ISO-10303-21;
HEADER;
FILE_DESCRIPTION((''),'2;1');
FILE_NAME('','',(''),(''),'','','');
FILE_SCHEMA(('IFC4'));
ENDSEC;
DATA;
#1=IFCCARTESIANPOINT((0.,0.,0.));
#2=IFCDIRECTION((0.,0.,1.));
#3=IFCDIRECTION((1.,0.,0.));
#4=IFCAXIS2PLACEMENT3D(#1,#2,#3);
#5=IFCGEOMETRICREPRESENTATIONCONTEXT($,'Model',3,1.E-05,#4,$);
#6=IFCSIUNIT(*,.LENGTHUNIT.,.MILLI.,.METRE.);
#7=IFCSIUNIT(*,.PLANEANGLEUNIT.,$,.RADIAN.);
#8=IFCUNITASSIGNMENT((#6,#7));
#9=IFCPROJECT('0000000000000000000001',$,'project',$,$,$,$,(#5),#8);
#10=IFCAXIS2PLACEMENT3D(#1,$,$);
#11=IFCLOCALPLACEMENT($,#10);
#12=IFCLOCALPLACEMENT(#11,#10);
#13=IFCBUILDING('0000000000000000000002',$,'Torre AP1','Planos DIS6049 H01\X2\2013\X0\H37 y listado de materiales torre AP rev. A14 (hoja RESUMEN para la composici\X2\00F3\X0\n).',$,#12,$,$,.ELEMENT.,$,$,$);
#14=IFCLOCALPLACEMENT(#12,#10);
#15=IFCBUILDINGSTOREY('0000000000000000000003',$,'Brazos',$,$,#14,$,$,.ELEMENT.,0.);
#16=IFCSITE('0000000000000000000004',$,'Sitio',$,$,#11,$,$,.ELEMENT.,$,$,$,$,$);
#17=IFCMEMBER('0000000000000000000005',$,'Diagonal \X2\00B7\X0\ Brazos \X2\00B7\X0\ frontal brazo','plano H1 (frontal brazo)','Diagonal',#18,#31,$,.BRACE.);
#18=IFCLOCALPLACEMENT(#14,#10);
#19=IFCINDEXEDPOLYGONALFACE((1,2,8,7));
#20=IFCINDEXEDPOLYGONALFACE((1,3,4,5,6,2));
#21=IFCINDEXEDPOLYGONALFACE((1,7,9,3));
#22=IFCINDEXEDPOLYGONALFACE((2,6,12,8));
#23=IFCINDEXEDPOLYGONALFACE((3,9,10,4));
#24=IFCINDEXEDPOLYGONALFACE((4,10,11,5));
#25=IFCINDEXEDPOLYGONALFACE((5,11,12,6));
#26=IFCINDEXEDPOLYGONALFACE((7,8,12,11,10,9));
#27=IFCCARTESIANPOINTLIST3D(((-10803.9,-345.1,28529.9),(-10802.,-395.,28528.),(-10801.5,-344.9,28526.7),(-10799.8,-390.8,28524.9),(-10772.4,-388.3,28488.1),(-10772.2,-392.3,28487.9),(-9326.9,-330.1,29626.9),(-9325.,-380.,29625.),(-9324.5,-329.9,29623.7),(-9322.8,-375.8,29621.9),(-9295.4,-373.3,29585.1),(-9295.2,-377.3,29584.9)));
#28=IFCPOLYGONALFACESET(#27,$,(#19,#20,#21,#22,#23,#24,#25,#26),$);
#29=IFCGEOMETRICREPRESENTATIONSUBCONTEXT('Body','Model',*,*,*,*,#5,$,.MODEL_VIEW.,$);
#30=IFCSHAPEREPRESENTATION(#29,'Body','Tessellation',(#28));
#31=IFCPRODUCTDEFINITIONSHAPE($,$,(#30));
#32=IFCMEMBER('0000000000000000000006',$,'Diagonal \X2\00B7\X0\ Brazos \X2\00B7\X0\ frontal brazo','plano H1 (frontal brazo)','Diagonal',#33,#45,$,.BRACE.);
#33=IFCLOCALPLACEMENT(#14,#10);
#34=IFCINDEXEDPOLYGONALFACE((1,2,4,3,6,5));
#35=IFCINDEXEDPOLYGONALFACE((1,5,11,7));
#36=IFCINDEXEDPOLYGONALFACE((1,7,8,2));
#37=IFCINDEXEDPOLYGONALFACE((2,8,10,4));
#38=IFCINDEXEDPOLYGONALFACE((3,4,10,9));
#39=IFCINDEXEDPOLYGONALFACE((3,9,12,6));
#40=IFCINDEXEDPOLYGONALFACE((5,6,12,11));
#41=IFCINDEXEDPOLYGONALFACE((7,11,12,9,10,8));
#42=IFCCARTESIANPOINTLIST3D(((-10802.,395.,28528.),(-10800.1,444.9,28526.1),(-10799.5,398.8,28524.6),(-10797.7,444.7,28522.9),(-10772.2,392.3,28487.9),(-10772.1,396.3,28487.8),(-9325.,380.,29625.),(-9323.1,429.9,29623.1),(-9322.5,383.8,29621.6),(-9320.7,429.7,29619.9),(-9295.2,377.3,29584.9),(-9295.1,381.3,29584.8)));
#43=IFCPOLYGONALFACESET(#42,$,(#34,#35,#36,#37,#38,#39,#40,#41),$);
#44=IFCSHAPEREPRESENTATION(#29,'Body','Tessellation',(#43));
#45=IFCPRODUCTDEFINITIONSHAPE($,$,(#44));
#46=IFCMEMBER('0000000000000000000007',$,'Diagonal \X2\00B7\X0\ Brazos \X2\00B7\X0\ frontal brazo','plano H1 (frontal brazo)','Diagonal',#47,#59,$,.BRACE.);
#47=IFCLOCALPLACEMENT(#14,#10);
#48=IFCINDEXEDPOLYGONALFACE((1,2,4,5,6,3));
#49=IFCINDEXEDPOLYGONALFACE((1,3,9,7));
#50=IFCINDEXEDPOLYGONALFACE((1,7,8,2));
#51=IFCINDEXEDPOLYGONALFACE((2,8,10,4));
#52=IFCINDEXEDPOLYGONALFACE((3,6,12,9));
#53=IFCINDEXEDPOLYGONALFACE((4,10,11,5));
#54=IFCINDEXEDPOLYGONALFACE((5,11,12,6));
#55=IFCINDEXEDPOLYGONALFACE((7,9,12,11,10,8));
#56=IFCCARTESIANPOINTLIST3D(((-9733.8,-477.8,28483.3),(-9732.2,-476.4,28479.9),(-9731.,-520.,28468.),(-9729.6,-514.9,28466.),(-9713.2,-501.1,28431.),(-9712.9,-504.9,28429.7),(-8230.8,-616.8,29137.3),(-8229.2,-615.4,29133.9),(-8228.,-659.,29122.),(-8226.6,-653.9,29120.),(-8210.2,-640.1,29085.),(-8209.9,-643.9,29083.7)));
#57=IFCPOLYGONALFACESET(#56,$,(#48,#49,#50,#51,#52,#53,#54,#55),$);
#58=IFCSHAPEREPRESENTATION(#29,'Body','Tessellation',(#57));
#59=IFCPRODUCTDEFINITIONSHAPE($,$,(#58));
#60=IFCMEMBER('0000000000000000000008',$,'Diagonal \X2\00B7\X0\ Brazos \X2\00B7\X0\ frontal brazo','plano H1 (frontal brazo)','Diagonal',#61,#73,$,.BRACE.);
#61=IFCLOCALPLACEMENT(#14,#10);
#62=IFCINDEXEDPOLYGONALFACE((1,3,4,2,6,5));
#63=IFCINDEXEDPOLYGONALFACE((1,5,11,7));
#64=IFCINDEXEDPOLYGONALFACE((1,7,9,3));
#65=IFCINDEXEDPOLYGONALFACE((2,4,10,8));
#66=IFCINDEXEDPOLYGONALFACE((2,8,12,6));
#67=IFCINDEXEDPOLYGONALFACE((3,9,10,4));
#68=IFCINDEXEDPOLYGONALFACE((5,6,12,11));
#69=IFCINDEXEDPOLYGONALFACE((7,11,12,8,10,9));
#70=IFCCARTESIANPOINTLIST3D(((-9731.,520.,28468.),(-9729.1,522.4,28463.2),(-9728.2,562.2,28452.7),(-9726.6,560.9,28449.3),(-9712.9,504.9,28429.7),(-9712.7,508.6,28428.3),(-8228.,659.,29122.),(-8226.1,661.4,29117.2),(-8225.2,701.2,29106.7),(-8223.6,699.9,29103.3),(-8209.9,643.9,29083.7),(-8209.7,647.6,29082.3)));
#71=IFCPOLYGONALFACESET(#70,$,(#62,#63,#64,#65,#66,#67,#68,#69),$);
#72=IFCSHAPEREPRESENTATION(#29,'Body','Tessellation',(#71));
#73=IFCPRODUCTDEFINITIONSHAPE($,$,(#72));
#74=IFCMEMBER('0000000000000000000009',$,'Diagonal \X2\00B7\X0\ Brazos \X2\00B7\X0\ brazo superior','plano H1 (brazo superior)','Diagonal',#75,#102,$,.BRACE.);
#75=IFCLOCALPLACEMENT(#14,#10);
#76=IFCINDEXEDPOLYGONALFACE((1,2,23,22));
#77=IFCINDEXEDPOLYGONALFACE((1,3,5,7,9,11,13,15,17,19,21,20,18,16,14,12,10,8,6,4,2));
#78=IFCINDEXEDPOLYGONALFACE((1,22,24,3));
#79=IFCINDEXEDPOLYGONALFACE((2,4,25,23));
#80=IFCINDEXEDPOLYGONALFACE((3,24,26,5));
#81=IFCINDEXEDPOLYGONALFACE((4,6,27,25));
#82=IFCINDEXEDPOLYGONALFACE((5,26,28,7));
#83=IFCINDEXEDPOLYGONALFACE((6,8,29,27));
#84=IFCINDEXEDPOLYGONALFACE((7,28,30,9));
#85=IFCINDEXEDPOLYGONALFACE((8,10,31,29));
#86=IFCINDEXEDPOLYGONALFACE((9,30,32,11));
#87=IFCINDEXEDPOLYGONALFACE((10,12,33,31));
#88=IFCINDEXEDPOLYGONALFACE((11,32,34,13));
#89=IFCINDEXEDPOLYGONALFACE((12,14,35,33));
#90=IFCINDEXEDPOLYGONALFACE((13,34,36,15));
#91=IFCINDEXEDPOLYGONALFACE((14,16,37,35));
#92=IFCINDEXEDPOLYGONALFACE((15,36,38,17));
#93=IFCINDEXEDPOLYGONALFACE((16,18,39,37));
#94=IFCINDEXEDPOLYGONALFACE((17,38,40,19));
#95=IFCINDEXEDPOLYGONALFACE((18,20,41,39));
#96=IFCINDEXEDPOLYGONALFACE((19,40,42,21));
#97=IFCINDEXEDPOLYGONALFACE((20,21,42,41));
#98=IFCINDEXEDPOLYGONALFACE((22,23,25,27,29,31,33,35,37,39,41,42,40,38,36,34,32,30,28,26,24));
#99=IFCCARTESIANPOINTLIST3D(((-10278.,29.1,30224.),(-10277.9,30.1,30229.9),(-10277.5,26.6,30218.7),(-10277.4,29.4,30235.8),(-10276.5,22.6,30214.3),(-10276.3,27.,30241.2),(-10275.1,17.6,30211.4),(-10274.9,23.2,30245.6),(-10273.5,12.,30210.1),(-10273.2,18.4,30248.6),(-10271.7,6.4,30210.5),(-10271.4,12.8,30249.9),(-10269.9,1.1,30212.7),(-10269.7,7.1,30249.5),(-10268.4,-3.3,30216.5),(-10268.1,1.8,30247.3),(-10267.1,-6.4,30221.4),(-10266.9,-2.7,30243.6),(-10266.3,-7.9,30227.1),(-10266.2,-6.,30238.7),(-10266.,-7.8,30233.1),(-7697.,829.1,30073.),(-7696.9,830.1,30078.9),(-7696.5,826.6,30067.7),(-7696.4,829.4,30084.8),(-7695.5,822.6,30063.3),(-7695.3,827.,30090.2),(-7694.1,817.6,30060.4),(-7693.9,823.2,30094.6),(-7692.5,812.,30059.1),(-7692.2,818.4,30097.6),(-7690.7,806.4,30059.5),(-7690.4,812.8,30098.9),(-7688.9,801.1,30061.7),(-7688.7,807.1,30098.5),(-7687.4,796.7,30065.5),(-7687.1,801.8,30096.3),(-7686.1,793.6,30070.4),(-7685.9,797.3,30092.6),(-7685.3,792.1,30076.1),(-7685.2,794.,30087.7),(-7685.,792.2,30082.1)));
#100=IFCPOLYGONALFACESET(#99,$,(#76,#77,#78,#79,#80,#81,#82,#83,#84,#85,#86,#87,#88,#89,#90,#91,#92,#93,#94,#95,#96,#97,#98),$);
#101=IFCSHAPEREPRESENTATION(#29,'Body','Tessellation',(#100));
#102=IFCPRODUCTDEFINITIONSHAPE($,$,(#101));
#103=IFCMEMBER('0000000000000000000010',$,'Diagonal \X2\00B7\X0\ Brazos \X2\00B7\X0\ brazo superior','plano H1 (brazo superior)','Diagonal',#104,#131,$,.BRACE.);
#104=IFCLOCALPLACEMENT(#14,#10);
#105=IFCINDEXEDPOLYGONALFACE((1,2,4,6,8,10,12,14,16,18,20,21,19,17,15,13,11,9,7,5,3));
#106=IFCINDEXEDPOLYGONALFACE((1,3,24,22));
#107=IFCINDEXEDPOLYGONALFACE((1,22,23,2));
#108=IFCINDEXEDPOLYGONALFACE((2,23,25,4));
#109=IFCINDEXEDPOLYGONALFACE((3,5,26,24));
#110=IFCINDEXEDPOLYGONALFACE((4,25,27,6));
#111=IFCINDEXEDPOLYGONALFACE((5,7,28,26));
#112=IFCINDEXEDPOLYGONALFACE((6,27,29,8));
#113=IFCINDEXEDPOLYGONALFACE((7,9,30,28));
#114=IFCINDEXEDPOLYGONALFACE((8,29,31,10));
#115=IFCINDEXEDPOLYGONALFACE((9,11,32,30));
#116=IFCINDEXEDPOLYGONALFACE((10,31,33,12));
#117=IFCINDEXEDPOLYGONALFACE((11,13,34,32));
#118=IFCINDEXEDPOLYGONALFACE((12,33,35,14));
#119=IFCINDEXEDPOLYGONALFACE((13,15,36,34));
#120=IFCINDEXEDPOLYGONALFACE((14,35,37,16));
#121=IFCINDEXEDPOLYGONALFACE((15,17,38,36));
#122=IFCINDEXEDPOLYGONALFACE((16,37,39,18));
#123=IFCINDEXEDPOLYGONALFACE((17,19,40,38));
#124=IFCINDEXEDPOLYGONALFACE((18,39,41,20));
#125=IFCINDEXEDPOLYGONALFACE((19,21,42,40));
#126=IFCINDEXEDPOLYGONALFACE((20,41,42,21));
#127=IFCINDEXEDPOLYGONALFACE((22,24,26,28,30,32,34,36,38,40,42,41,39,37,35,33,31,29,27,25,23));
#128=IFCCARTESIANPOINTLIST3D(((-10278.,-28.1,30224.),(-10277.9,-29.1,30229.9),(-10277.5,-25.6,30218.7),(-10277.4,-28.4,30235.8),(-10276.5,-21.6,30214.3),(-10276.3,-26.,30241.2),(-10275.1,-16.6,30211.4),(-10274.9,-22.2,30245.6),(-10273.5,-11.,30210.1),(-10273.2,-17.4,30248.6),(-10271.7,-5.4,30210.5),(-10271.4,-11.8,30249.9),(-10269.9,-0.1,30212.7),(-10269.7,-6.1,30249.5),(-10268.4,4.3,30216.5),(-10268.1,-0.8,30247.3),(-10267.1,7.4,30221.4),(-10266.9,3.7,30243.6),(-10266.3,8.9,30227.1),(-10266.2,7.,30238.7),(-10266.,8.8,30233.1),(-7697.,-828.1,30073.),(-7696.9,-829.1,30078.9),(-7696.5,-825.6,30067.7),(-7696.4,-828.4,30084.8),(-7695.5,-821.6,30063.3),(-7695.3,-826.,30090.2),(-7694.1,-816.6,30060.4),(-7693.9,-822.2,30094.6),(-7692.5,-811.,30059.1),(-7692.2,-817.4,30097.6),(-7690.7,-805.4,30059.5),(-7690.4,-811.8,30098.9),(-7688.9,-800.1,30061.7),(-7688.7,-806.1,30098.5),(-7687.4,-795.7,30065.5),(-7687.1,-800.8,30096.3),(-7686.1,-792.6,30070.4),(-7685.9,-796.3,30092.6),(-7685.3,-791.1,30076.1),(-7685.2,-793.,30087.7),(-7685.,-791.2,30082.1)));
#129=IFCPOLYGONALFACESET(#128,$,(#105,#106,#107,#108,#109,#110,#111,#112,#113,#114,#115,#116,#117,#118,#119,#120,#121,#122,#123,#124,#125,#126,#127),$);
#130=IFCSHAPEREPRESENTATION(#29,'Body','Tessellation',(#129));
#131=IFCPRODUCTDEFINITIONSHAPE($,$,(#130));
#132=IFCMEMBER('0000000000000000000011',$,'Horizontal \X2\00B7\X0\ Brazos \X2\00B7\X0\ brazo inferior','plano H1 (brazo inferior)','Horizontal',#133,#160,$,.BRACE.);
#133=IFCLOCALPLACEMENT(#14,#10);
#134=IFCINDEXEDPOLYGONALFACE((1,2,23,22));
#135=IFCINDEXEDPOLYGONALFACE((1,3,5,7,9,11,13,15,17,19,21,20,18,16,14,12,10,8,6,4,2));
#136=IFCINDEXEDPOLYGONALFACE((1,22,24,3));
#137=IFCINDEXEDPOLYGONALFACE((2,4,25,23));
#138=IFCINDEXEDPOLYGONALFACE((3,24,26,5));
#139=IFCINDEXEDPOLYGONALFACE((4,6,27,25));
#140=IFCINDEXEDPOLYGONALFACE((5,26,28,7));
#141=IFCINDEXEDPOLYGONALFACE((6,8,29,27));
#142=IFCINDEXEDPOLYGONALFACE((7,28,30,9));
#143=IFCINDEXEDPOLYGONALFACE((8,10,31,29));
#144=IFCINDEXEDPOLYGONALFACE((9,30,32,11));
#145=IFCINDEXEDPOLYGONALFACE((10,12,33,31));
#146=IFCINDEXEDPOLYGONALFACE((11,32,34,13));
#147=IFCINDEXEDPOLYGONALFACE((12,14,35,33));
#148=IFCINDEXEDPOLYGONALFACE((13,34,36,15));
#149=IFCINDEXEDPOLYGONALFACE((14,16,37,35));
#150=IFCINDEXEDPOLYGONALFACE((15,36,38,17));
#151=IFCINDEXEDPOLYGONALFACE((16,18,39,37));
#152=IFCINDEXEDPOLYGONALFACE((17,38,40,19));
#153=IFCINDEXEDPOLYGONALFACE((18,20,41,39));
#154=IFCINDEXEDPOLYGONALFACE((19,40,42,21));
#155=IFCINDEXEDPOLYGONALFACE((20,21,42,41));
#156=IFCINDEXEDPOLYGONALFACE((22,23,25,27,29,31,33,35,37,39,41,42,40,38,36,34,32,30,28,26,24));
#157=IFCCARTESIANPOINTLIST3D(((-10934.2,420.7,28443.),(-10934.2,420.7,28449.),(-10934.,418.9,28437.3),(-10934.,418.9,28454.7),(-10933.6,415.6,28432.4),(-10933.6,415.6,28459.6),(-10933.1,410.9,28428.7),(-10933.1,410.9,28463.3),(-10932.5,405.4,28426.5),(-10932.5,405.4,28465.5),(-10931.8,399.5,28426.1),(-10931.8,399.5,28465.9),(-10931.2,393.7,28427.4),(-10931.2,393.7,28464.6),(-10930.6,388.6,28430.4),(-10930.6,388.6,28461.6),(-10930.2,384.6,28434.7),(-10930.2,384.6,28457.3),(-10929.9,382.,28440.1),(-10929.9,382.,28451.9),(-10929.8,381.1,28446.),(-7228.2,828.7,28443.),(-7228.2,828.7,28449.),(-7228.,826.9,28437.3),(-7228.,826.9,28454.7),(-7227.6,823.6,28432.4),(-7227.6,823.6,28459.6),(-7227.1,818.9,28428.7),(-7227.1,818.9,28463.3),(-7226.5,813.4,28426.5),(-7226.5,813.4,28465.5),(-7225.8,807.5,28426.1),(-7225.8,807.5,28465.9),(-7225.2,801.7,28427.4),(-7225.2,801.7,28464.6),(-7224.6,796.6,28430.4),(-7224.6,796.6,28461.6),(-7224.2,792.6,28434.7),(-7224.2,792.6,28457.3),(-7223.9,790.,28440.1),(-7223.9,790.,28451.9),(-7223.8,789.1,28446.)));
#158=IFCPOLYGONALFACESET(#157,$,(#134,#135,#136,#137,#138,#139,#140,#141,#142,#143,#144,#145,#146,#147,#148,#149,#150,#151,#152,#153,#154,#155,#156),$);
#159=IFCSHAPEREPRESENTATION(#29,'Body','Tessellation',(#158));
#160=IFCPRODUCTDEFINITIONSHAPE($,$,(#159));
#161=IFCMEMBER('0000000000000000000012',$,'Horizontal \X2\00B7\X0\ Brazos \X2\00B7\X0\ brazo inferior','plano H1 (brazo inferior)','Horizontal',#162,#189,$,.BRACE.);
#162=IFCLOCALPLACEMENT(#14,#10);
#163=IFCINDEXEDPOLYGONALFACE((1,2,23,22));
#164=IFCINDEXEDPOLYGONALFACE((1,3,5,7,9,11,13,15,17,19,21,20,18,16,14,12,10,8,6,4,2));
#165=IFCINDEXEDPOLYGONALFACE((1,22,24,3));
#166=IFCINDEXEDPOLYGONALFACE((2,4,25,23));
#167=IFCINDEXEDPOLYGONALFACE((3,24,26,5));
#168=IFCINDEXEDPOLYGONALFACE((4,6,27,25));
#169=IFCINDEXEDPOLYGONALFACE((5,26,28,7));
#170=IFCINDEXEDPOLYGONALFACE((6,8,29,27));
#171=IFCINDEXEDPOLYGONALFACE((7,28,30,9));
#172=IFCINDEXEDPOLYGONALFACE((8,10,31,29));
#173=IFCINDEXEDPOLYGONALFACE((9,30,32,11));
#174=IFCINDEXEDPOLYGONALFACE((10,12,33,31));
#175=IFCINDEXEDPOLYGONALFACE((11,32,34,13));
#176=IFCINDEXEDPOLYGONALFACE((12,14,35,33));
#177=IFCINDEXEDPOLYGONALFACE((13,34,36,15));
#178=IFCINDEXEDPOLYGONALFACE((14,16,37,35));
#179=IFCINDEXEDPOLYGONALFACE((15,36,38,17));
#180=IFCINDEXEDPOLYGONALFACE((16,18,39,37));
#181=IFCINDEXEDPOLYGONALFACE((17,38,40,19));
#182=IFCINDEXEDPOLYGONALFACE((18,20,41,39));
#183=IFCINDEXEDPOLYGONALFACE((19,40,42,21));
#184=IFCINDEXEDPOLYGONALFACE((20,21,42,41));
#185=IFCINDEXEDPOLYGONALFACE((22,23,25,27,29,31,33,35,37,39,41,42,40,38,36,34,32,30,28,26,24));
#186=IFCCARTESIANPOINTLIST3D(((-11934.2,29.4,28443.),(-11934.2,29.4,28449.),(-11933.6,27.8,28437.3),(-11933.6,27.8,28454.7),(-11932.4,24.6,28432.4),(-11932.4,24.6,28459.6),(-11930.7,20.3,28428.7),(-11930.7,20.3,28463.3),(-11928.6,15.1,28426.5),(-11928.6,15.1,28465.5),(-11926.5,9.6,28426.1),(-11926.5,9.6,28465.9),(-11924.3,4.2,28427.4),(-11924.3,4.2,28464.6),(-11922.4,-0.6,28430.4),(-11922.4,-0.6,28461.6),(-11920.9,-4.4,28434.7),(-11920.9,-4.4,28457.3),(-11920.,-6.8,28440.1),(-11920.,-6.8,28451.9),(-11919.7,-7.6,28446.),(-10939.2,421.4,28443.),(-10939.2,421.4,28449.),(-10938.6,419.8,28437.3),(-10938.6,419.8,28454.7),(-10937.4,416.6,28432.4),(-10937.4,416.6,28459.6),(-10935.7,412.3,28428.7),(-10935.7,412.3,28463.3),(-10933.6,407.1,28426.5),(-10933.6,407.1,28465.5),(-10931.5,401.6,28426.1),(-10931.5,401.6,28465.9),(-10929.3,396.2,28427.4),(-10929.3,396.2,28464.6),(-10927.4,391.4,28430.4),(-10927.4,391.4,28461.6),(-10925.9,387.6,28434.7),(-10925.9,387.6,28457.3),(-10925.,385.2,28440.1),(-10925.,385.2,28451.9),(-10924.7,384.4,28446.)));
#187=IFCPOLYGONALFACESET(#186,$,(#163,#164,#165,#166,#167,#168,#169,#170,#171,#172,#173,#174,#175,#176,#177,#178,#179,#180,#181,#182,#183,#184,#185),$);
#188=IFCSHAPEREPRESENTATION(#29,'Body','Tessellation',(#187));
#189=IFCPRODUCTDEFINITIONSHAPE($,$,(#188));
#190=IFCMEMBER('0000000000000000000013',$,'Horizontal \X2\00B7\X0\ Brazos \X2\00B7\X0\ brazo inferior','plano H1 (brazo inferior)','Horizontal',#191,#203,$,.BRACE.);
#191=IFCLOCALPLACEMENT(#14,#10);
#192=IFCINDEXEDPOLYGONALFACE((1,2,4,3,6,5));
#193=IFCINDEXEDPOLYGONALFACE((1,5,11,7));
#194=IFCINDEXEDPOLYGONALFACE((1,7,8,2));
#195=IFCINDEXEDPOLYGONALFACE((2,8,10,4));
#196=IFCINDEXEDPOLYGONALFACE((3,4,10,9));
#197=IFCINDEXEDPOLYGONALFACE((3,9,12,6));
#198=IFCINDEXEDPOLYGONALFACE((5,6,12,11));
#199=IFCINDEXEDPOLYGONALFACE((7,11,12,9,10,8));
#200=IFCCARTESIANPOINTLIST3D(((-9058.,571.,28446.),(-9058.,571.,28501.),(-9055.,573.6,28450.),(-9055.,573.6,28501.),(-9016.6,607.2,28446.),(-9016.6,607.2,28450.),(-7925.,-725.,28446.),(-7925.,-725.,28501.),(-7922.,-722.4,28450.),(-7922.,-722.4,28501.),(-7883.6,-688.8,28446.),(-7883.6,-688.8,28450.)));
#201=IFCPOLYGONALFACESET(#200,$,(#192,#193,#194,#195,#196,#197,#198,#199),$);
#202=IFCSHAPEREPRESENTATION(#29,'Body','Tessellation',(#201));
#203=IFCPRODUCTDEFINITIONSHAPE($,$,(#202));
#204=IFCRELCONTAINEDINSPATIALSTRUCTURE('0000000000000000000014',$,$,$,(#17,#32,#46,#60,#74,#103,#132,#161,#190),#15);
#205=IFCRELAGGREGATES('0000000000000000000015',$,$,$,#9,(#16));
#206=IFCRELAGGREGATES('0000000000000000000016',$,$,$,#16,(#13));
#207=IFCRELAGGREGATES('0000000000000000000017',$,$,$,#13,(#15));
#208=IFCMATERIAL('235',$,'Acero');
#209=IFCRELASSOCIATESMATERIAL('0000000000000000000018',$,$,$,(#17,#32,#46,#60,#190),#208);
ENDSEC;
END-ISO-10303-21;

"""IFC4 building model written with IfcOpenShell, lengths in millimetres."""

from ifc_helpers import new_model, si_unit, frame, frame_2d, origin, origin_with_axes, place, context, subcontext, project, spatial, circle, l_section, extrude, material, element, save


model = new_model("IFC4")

# Units and contexts
model_context = context("Model", 3, precision=1e-05, world=origin_with_axes())
body_context = subcontext(model_context, "Body", "Model", "MODEL_VIEW")
ifc_project = project(units=[si_unit("LENGTHUNIT", "METRE", prefix="MILLI"), si_unit("PLANEANGLEUNIT", "RADIAN")], contexts=[model_context])

# Site, building, storey
site_placement = place(None, origin())
site = spatial("IfcSite", under=ifc_project, at=site_placement, Name="Sitio", CompositionType="ELEMENT")
building_placement = place(site_placement, origin())
building = spatial("IfcBuilding", under=site, at=building_placement, Name="Torre AP1", Description="Planos DIS6049 H01–H37 y listado de materiales torre AP rev. A14 (hoja RESUMEN para la composición).", CompositionType="ELEMENT")
storey_placement = place(building_placement, origin())
storey = spatial("IfcBuildingStorey", under=building, at=storey_placement, Name="Brazos", CompositionType="ELEMENT", Elevation=0.0)

# Members
ifc_material_1 = material(Name="235", Category="Acero")
for number, where, z_axis, x_axis, name in (
    (1, (-10802.0, -395.0, 28528.0), (0.802769, 0.008153, 0.596234), (0.595049, 0.053521, -0.801905), "Diagonal · Brazos · frontal brazo"),
    (2, (-10802.0, 395.0, 28528.0), (0.802769, -0.008153, 0.596234), (0.595049, -0.053521, -0.801905), "Diagonal · Brazos · frontal brazo"),
):
    element("IfcMember", number, at=place(storey_placement, frame(where, z_axis=z_axis, x_axis=x_axis)), inside=storey, material=ifc_material_1, Name=name, Description="plano H1 (frontal brazo)", ObjectType="Diagonal", PredefinedType="BRACE", context=body_context, shape_type="SweptSolid", body=[
        extrude(l_section(Depth=50.0, Width=50.0, Thickness=4.0, at=frame_2d((25.0, 25.0))), None, (0.0, 0.0, 1.0), 1839.9),
    ])
for number, where, z_axis, x_axis, name in (
    (3, (-9731.0, -520.0, 28468.0), (0.913674, -0.084498, 0.397567), (0.401755, 0.335963, -0.851893), "Diagonal · Brazos · frontal brazo"),
    (4, (-9731.0, 520.0, 28468.0), (0.913674, 0.084498, 0.397567), (0.401755, -0.335963, -0.851893), "Diagonal · Brazos · frontal brazo"),
):
    element("IfcMember", number, at=place(storey_placement, frame(where, z_axis=z_axis, x_axis=x_axis)), inside=storey, material=ifc_material_1, Name=name, Description="plano H1 (frontal brazo)", ObjectType="Diagonal", PredefinedType="BRACE", context=body_context, shape_type="SweptSolid", body=[
        extrude(l_section(Depth=45.0, Width=45.0, Thickness=4.0, at=frame_2d((22.5, 22.5))), None, (0.0, 0.0, 1.0), 1645.0),
    ])
for number, where, z_axis, x_axis, name in (
    (5, (-7691.0, 811.0, 30079.0), (-0.953681, -0.2956, 0.055795), (0.300728, -0.941427, 0.152572), "Diagonal · Brazos · brazo superior"),
    (6, (-10272.0, -10.0, 30230.0), (0.953681, -0.2956, -0.055795), (0.300729, 0.941418, 0.152624), "Diagonal · Brazos · brazo superior"),
):
    element("IfcMember", number, at=place(storey_placement, frame(where, z_axis=z_axis, x_axis=x_axis)), inside=storey, Name=name, Description="plano H1 (brazo superior)", ObjectType="Diagonal", PredefinedType="BRACE", context=body_context, shape_type="SweptSolid", body=[
        extrude(circle(Radius=20.0), None, (0.0, 0.0, 1.0), 2706.4),
    ])
member_1_placement = place(storey_placement, frame((-7226.0, 809.0, 28446.0), z_axis=(-0.993994, -0.109431, 0.0), x_axis=(0.109431, -0.993994, 0.0)))
element("IfcMember", 7, at=member_1_placement, inside=storey, Name="Horizontal · Brazos · brazo inferior", Description="plano H1 (brazo inferior)", ObjectType="Horizontal", PredefinedType="BRACE", context=body_context, shape_type="SweptSolid", body=[
    extrude(circle(Radius=20.0), None, (0.0, 0.0, 1.0), 3728.4),
])
member_2_placement = place(storey_placement, frame((-10932.0, 403.0, 28446.0), z_axis=(-0.930399, -0.366549, 0.0), x_axis=(0.366549, -0.930399, 0.0)))
element("IfcMember", 8, at=member_2_placement, inside=storey, Name="Horizontal · Brazos · brazo inferior", Description="plano H1 (brazo inferior)", ObjectType="Horizontal", PredefinedType="BRACE", context=body_context, shape_type="SweptSolid", body=[
    extrude(circle(Radius=20.0), None, (0.0, 0.0, 1.0), 1069.4),
])
member_3_placement = place(storey_placement, frame((-9058.0, 571.0, 28446.0), z_axis=(0.658176, -0.752865, 0.0), x_axis=(0.752865, 0.658176, 0.0)))
element("IfcMember", 9, at=member_3_placement, inside=storey, material=ifc_material_1, Name="Horizontal · Brazos · brazo inferior", Description="plano H1 (brazo inferior)", ObjectType="Horizontal", PredefinedType="BRACE", context=body_context, shape_type="SweptSolid", body=[
    extrude(l_section(Depth=55.0, Width=55.0, Thickness=4.0, at=frame_2d((27.5, 27.5))), None, (0.0, 0.0, 1.0), 1721.4),
])

save(model, "model.ifc")
